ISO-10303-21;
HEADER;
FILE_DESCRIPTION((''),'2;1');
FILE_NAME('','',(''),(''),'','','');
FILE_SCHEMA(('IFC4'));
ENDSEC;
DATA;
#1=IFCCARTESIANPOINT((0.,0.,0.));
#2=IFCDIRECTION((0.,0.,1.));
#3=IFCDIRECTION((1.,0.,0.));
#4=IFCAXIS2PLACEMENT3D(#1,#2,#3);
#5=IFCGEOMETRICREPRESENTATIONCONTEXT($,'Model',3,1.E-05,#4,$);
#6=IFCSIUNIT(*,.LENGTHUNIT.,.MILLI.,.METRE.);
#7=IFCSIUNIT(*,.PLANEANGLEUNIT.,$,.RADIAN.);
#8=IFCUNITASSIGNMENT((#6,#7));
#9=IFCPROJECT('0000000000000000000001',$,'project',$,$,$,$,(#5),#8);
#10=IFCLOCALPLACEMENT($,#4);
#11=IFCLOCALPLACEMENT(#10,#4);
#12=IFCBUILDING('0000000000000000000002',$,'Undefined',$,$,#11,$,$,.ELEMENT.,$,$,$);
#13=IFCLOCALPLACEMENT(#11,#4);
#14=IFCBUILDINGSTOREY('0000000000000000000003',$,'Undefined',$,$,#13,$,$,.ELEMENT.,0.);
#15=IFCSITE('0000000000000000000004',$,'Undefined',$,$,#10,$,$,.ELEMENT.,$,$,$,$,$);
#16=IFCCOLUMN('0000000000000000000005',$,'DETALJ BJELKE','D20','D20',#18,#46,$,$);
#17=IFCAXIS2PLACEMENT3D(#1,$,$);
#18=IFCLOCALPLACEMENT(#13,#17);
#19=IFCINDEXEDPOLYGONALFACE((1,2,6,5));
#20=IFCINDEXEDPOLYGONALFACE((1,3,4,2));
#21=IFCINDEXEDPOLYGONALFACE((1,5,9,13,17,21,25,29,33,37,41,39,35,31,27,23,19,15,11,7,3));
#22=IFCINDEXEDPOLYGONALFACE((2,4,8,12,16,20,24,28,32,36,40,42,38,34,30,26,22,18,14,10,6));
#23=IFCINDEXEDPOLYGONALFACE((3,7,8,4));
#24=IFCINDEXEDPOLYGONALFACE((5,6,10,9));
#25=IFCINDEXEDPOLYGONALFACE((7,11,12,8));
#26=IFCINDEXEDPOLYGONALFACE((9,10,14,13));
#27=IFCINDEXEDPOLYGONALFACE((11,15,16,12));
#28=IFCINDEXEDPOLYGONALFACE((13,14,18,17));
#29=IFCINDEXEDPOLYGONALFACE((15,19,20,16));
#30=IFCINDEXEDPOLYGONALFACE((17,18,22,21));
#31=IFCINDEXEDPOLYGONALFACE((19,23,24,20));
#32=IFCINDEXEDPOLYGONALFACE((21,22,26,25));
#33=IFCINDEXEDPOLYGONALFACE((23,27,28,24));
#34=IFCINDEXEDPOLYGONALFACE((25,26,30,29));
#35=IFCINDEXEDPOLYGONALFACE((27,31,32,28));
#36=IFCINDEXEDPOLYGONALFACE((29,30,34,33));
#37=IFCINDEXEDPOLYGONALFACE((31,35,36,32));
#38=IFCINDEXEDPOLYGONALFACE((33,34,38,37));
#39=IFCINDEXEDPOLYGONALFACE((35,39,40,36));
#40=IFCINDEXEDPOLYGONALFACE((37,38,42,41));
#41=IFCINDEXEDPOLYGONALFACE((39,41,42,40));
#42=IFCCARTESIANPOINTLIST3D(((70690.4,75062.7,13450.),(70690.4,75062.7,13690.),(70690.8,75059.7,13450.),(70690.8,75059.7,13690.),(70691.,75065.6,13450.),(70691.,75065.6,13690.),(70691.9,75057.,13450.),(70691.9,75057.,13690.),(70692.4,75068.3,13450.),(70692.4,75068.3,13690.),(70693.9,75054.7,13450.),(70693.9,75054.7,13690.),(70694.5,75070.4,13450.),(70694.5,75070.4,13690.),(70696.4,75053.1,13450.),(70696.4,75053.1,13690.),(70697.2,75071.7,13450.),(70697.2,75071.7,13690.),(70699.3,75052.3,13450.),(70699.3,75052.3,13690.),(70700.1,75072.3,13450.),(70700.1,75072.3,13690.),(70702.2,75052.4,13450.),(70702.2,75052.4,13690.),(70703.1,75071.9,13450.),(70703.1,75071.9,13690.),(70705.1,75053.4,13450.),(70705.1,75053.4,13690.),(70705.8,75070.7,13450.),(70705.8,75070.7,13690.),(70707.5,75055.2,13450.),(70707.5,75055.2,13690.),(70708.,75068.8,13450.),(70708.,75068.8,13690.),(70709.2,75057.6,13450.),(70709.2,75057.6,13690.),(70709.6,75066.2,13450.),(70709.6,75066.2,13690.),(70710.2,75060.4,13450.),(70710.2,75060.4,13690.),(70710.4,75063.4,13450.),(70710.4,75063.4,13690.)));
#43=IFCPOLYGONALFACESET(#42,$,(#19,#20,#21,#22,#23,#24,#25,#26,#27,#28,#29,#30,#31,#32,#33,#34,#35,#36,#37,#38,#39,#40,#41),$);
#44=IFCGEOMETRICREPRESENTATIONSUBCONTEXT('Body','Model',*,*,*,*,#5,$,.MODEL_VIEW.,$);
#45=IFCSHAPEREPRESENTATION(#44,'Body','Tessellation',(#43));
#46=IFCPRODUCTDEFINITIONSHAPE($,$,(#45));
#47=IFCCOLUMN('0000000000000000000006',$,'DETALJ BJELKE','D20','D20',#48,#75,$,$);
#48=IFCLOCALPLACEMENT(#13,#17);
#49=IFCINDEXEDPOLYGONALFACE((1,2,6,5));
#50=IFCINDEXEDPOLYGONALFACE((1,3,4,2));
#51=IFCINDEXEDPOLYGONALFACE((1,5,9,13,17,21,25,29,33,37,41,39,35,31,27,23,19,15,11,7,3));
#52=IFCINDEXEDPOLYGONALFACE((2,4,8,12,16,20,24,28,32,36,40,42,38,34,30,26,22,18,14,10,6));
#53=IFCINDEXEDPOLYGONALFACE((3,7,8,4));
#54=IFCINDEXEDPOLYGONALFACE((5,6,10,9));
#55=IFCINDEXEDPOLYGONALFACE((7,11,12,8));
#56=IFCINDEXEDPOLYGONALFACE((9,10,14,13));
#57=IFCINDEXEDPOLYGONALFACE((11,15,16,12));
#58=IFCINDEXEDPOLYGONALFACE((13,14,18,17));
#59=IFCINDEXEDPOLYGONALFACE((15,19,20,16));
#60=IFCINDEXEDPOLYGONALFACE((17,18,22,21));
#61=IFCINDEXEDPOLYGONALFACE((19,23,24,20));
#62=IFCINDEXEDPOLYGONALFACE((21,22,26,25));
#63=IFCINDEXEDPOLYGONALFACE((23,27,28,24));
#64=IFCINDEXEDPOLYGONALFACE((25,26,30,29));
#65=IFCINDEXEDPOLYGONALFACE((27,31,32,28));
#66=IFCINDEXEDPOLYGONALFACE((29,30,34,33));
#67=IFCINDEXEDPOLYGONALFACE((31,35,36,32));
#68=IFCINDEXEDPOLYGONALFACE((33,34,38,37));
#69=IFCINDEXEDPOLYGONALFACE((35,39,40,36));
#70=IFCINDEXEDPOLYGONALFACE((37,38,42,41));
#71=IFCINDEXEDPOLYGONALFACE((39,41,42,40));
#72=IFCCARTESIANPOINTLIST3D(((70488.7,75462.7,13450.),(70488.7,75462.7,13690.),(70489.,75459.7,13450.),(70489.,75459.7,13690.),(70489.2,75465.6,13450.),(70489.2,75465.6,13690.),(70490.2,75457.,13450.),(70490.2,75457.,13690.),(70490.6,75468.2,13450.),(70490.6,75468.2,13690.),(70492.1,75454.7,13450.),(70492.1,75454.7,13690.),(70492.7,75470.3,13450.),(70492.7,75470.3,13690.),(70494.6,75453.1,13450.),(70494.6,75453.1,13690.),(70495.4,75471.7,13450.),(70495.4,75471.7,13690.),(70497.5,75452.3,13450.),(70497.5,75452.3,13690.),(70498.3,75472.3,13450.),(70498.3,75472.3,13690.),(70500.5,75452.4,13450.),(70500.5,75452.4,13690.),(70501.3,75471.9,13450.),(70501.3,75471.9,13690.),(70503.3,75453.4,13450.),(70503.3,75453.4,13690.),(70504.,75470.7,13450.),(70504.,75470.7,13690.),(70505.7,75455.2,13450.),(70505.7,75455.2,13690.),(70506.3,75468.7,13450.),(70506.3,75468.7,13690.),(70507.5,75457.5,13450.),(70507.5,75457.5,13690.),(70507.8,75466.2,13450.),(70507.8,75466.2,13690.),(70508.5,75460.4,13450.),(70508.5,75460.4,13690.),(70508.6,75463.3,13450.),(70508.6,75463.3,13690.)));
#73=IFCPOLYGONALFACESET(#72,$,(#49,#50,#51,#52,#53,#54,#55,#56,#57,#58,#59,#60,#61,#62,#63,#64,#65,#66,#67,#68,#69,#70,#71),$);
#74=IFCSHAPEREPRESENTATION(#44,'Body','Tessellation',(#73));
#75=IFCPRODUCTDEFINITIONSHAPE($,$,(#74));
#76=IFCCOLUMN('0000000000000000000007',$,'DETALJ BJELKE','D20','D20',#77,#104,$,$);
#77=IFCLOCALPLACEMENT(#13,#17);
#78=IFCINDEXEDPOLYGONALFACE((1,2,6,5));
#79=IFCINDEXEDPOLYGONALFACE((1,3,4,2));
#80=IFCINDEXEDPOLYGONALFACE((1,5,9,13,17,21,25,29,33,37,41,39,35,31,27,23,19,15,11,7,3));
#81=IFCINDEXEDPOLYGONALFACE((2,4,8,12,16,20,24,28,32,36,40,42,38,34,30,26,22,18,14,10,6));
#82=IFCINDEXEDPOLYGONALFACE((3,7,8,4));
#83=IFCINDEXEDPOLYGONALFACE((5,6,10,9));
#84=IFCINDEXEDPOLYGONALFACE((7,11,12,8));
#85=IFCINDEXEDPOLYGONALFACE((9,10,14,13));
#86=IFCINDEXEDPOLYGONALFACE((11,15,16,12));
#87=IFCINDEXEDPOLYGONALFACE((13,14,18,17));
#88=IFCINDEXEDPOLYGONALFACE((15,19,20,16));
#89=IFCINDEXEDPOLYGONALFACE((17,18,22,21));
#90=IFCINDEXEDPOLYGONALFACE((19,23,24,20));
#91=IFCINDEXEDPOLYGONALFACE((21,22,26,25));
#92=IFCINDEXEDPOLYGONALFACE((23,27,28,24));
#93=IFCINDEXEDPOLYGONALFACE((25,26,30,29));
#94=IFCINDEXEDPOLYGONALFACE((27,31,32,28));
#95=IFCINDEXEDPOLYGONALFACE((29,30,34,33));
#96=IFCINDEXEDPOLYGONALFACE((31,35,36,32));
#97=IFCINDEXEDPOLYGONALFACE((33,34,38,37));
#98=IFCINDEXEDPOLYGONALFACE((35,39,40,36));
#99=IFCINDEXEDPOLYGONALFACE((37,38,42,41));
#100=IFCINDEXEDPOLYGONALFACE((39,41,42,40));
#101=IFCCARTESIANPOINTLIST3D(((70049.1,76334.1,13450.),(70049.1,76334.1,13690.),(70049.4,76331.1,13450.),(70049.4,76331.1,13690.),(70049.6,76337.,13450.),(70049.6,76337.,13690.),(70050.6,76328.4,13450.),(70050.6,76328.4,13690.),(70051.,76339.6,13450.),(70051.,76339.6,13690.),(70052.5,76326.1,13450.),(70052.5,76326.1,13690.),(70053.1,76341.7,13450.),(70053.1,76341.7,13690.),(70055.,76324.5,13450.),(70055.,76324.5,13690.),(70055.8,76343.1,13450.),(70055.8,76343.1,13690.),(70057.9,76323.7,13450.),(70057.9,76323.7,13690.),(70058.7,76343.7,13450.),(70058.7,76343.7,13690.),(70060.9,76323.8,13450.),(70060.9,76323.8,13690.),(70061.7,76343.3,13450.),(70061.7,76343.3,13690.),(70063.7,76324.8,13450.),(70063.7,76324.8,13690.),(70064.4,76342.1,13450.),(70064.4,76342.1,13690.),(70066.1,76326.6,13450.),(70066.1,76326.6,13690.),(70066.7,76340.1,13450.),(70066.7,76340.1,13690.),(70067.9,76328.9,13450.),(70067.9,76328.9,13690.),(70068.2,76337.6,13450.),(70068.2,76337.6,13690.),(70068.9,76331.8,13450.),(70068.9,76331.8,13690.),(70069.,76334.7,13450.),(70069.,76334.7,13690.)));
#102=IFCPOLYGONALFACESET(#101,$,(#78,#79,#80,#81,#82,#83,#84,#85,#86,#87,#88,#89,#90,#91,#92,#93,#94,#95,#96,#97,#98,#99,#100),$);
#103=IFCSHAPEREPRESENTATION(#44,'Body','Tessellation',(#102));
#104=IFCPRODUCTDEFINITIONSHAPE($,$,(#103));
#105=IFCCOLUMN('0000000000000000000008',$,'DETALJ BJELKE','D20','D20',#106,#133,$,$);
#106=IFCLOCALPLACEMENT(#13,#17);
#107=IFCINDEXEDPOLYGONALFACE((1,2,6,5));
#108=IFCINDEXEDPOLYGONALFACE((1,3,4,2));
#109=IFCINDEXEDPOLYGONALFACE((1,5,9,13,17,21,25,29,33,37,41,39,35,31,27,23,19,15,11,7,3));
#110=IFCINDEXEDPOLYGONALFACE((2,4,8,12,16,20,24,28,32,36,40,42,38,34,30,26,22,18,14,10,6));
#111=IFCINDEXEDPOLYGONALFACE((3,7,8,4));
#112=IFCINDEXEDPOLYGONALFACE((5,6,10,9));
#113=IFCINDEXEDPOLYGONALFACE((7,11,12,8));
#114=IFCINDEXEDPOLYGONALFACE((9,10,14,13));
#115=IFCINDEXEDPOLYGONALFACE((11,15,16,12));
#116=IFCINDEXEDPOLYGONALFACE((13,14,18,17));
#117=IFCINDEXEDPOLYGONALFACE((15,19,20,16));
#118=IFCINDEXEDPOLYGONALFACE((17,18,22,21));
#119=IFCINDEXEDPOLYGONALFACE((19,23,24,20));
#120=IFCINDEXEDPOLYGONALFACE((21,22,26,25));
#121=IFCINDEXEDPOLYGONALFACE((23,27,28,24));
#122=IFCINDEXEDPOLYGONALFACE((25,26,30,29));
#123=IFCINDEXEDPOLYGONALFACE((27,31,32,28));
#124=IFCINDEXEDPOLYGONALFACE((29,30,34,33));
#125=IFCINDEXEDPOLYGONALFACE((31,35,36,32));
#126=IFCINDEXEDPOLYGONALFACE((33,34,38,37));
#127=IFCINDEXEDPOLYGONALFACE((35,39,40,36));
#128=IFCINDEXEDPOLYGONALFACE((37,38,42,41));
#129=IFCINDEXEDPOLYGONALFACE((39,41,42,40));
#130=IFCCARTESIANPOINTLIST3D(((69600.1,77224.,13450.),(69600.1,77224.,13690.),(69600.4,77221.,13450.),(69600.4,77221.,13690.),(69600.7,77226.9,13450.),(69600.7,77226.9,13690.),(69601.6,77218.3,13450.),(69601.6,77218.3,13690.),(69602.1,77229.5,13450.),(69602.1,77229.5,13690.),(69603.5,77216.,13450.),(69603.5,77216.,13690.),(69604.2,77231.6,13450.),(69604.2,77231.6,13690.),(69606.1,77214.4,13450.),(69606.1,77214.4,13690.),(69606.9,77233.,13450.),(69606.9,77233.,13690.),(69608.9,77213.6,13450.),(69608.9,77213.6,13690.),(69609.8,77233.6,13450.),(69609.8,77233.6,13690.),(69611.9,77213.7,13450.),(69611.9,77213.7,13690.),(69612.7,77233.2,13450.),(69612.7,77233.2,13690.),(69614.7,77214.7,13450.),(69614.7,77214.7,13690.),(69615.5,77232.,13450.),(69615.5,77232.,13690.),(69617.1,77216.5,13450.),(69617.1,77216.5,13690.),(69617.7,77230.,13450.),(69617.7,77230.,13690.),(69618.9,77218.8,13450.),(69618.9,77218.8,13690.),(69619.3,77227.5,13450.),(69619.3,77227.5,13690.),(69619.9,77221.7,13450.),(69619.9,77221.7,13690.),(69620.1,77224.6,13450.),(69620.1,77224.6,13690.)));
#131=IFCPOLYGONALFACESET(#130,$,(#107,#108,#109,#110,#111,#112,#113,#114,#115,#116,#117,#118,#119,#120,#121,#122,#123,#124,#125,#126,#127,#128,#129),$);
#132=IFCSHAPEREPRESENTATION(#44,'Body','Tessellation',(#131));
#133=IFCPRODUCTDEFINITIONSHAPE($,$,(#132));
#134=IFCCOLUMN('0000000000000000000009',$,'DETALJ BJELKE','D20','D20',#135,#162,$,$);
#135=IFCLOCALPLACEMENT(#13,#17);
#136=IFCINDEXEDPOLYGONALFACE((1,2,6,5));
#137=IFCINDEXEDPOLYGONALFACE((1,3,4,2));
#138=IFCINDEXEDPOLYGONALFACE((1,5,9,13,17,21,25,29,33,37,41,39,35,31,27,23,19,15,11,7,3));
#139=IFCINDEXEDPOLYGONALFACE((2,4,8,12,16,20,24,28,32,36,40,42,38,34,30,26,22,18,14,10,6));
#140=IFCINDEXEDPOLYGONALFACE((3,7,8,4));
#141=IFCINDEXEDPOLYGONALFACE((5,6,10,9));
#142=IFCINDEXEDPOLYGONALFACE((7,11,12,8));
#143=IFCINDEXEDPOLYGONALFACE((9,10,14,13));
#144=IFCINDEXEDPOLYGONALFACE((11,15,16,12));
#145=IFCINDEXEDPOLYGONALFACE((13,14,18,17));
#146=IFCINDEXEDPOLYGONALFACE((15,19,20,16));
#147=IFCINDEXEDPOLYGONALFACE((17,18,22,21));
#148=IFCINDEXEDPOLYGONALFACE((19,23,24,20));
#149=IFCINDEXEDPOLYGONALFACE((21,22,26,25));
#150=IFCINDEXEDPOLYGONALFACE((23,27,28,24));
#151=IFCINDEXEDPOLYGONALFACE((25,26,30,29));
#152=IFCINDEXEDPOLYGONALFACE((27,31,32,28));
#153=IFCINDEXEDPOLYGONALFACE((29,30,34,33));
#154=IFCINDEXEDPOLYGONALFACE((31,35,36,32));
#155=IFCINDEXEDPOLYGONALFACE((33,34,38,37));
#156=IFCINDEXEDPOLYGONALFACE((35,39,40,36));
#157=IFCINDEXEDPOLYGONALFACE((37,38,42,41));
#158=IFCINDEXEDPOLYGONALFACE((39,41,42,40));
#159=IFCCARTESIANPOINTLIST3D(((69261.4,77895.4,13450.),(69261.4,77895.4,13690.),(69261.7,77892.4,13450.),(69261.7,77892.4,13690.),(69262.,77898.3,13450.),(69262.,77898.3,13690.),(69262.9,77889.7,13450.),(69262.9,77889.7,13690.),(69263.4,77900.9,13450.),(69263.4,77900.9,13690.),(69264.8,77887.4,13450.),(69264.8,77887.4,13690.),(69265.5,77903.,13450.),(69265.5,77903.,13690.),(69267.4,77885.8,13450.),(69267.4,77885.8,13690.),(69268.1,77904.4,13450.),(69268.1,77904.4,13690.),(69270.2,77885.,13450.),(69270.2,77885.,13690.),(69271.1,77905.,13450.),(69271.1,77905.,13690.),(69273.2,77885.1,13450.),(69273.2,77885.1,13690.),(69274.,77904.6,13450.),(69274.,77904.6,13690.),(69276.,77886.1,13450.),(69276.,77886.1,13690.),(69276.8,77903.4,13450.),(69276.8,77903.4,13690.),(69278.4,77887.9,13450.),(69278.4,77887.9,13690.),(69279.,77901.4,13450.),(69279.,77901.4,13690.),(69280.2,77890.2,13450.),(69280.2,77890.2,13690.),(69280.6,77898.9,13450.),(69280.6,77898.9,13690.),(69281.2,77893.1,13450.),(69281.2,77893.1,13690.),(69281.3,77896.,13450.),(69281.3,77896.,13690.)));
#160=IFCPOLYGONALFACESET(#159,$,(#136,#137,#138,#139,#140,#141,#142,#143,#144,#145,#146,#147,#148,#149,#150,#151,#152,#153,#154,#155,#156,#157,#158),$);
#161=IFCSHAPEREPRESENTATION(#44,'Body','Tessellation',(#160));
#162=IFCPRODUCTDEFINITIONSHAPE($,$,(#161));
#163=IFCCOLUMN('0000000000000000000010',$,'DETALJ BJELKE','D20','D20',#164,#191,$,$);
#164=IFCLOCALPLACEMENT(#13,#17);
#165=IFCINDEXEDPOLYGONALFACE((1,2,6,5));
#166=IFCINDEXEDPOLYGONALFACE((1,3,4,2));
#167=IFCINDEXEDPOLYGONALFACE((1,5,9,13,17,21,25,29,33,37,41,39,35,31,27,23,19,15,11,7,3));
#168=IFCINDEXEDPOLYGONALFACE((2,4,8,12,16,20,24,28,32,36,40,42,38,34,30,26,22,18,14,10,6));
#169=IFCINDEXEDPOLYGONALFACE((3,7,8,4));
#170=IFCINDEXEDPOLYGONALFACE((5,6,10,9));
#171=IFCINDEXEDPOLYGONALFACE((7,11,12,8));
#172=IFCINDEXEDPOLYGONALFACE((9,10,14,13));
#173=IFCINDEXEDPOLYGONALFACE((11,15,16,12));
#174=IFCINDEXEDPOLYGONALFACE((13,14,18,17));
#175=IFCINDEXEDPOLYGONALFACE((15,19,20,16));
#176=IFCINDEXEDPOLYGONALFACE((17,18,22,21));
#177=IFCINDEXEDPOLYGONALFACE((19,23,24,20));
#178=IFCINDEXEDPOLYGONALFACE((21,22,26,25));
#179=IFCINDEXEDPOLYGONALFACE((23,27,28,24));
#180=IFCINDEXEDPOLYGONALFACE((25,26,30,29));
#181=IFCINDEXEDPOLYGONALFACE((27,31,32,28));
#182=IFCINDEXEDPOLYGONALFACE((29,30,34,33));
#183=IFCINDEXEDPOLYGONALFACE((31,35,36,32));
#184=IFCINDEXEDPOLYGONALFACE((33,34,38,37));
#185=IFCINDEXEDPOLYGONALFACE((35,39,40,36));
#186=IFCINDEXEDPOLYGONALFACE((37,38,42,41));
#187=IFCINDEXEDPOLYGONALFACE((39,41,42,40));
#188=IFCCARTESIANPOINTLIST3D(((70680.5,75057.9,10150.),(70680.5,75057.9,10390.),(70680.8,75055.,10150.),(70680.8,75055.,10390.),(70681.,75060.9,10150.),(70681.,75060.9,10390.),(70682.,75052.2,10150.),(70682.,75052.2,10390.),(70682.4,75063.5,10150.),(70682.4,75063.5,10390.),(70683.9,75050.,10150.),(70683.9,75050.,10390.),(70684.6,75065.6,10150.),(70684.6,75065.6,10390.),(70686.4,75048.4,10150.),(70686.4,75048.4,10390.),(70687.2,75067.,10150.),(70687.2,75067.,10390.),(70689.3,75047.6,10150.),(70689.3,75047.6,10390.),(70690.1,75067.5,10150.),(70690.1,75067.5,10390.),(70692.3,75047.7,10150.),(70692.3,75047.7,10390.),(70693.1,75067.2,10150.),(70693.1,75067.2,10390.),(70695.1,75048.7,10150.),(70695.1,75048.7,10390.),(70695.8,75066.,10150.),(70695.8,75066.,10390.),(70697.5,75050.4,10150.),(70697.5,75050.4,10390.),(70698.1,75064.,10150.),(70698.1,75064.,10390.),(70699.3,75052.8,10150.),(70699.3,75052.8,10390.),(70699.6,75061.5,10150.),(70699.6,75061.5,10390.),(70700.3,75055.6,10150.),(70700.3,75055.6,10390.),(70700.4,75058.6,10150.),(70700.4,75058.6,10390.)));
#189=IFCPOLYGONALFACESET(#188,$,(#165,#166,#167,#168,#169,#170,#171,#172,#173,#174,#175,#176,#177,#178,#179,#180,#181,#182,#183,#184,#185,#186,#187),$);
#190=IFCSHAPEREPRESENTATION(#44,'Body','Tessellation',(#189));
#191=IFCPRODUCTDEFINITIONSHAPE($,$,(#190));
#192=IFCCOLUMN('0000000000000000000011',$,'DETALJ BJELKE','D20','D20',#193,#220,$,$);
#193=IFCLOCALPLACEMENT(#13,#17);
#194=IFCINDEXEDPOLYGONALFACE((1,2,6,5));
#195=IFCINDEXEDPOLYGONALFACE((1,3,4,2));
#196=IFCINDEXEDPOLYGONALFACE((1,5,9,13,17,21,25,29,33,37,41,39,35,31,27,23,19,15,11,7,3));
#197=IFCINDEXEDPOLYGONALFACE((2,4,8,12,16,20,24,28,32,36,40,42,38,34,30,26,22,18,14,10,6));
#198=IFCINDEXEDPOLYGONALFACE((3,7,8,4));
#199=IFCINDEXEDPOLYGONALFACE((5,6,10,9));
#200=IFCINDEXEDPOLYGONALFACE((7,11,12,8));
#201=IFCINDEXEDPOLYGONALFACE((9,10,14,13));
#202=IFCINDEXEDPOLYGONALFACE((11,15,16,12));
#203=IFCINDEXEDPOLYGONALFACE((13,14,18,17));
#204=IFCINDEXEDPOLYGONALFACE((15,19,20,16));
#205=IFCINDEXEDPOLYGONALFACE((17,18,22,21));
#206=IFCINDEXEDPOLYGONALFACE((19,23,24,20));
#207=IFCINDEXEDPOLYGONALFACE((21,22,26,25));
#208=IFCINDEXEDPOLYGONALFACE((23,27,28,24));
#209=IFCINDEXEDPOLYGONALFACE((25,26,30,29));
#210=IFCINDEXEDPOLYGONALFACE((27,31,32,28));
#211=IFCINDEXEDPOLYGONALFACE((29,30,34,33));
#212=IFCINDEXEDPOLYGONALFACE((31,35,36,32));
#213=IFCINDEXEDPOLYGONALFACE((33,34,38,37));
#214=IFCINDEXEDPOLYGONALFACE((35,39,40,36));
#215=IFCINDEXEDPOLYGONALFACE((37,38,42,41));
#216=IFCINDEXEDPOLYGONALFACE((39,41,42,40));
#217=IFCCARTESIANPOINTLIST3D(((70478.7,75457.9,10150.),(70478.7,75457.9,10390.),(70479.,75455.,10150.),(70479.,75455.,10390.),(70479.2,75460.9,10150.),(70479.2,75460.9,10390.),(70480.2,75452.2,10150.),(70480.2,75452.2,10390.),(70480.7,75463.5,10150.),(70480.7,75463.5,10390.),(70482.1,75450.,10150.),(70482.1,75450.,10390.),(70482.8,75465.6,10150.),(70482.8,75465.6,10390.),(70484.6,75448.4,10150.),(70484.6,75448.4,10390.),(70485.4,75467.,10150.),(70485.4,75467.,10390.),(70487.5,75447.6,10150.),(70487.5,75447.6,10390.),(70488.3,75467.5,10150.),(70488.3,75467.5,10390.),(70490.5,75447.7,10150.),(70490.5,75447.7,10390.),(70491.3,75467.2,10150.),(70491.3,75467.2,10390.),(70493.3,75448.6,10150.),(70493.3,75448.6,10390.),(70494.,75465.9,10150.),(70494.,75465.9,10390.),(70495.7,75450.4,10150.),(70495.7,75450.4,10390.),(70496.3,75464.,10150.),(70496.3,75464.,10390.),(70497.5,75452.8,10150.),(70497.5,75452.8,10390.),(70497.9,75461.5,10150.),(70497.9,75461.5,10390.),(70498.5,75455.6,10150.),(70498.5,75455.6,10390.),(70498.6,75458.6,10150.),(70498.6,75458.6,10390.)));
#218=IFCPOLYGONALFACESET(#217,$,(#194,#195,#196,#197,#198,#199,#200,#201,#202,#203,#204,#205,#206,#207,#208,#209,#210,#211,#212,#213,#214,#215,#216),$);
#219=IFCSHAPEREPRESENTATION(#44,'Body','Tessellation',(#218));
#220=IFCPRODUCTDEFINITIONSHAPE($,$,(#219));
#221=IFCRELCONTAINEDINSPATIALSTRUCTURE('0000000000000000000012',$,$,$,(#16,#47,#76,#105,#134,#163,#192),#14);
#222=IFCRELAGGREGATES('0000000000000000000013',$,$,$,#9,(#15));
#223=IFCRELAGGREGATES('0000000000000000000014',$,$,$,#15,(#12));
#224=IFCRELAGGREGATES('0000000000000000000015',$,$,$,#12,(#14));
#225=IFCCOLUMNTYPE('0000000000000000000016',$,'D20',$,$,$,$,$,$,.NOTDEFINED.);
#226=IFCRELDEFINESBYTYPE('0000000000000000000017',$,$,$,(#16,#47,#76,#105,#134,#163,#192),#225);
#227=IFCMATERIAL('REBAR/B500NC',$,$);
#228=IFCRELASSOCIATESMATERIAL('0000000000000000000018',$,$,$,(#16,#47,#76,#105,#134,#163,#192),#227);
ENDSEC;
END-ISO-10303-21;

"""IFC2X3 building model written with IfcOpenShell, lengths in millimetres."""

from ifc_helpers import new_model, si_unit, frame, origin_with_axes, origin_2d_with_axis, place, context, subcontext, project, spatial, circle, extrude, material, type_object, element, save


model = new_model("IFC2X3")

# Units and contexts
model_context = context("Model", 3, precision=1e-05, world=origin_with_axes())
body_context = subcontext(model_context, "Body", "Model", "MODEL_VIEW")
ifc_project = project(units=[si_unit("LENGTHUNIT", "METRE", prefix="MILLI"), si_unit("PLANEANGLEUNIT", "RADIAN")], contexts=[model_context])

# Site, building, storey
site_placement = place(None, origin_with_axes())
site = spatial("IfcSite", under=ifc_project, at=site_placement, Name="Undefined", CompositionType="ELEMENT")
building_placement = place(site_placement, origin_with_axes())
building = spatial("IfcBuilding", under=site, at=building_placement, Name="Undefined", CompositionType="ELEMENT")
storey_placement = place(building_placement, origin_with_axes())
storey = spatial("IfcBuildingStorey", under=building, at=storey_placement, Name="Undefined", CompositionType="ELEMENT", Elevation=0.0)

# Columns
ifc_material_1 = material(Name="REBAR/B500NC")
column_type = type_object("IfcColumnType", Name="D20", PredefinedType="NOTDEFINED")
for number, where, z_axis, x_axis, name in (
    (1, (70700.4, 75062.3, 13450.0), (0.0, 0.0, 1.0), (-0.886365, -0.462987, 0.0), "DETALJ BJELKE"),
    (2, (70498.6, 75462.3, 13450.0), (0.0, 0.0, 1.0), (-0.886365, -0.462987, 0.0), "DETALJ BJELKE"),
    (3, (70059.0, 76333.7, 13450.0), (0.0, 0.0, 1.0), (-0.886365, -0.462987, 0.0), "DETALJ BJELKE"),
    (4, (69610.1, 77223.6, 13450.0), (0.0, 0.0, 1.0), (-0.886365, -0.462987, 0.0), "DETALJ BJELKE"),
    (5, (69271.4, 77895.0, 13450.0), (0.0, 0.0, 1.0), (-0.886365, -0.462987, 0.0), "DETALJ BJELKE"),
    (6, (70690.5, 75057.5, 10150.0), (0.0, 0.0, 1.0), (-0.886365, -0.462987, 0.0), "DETALJ BJELKE"),
    (7, (70488.7, 75457.5, 10150.0), (0.0, 0.0, 1.0), (-0.886365, -0.462987, 0.0), "DETALJ BJELKE"),
):
    element("IfcColumn", number, at=place(storey_placement, frame(where, z_axis=z_axis, x_axis=x_axis)), inside=storey, type_object=column_type, material=ifc_material_1, Name=name, Description="D20", ObjectType="D20", context=body_context, shape_type="SweptSolid", body=[
        extrude(circle(Radius=10.0, at=origin_2d_with_axis()), frame((0.0, 0.0, 240.0), z_axis=(0.0, 0.0, -1.0), x_axis=(0.0, 1.0, 0.0)), (0.0, 0.0, 1.0), 240.0),
    ])

save(model, "model.ifc")
